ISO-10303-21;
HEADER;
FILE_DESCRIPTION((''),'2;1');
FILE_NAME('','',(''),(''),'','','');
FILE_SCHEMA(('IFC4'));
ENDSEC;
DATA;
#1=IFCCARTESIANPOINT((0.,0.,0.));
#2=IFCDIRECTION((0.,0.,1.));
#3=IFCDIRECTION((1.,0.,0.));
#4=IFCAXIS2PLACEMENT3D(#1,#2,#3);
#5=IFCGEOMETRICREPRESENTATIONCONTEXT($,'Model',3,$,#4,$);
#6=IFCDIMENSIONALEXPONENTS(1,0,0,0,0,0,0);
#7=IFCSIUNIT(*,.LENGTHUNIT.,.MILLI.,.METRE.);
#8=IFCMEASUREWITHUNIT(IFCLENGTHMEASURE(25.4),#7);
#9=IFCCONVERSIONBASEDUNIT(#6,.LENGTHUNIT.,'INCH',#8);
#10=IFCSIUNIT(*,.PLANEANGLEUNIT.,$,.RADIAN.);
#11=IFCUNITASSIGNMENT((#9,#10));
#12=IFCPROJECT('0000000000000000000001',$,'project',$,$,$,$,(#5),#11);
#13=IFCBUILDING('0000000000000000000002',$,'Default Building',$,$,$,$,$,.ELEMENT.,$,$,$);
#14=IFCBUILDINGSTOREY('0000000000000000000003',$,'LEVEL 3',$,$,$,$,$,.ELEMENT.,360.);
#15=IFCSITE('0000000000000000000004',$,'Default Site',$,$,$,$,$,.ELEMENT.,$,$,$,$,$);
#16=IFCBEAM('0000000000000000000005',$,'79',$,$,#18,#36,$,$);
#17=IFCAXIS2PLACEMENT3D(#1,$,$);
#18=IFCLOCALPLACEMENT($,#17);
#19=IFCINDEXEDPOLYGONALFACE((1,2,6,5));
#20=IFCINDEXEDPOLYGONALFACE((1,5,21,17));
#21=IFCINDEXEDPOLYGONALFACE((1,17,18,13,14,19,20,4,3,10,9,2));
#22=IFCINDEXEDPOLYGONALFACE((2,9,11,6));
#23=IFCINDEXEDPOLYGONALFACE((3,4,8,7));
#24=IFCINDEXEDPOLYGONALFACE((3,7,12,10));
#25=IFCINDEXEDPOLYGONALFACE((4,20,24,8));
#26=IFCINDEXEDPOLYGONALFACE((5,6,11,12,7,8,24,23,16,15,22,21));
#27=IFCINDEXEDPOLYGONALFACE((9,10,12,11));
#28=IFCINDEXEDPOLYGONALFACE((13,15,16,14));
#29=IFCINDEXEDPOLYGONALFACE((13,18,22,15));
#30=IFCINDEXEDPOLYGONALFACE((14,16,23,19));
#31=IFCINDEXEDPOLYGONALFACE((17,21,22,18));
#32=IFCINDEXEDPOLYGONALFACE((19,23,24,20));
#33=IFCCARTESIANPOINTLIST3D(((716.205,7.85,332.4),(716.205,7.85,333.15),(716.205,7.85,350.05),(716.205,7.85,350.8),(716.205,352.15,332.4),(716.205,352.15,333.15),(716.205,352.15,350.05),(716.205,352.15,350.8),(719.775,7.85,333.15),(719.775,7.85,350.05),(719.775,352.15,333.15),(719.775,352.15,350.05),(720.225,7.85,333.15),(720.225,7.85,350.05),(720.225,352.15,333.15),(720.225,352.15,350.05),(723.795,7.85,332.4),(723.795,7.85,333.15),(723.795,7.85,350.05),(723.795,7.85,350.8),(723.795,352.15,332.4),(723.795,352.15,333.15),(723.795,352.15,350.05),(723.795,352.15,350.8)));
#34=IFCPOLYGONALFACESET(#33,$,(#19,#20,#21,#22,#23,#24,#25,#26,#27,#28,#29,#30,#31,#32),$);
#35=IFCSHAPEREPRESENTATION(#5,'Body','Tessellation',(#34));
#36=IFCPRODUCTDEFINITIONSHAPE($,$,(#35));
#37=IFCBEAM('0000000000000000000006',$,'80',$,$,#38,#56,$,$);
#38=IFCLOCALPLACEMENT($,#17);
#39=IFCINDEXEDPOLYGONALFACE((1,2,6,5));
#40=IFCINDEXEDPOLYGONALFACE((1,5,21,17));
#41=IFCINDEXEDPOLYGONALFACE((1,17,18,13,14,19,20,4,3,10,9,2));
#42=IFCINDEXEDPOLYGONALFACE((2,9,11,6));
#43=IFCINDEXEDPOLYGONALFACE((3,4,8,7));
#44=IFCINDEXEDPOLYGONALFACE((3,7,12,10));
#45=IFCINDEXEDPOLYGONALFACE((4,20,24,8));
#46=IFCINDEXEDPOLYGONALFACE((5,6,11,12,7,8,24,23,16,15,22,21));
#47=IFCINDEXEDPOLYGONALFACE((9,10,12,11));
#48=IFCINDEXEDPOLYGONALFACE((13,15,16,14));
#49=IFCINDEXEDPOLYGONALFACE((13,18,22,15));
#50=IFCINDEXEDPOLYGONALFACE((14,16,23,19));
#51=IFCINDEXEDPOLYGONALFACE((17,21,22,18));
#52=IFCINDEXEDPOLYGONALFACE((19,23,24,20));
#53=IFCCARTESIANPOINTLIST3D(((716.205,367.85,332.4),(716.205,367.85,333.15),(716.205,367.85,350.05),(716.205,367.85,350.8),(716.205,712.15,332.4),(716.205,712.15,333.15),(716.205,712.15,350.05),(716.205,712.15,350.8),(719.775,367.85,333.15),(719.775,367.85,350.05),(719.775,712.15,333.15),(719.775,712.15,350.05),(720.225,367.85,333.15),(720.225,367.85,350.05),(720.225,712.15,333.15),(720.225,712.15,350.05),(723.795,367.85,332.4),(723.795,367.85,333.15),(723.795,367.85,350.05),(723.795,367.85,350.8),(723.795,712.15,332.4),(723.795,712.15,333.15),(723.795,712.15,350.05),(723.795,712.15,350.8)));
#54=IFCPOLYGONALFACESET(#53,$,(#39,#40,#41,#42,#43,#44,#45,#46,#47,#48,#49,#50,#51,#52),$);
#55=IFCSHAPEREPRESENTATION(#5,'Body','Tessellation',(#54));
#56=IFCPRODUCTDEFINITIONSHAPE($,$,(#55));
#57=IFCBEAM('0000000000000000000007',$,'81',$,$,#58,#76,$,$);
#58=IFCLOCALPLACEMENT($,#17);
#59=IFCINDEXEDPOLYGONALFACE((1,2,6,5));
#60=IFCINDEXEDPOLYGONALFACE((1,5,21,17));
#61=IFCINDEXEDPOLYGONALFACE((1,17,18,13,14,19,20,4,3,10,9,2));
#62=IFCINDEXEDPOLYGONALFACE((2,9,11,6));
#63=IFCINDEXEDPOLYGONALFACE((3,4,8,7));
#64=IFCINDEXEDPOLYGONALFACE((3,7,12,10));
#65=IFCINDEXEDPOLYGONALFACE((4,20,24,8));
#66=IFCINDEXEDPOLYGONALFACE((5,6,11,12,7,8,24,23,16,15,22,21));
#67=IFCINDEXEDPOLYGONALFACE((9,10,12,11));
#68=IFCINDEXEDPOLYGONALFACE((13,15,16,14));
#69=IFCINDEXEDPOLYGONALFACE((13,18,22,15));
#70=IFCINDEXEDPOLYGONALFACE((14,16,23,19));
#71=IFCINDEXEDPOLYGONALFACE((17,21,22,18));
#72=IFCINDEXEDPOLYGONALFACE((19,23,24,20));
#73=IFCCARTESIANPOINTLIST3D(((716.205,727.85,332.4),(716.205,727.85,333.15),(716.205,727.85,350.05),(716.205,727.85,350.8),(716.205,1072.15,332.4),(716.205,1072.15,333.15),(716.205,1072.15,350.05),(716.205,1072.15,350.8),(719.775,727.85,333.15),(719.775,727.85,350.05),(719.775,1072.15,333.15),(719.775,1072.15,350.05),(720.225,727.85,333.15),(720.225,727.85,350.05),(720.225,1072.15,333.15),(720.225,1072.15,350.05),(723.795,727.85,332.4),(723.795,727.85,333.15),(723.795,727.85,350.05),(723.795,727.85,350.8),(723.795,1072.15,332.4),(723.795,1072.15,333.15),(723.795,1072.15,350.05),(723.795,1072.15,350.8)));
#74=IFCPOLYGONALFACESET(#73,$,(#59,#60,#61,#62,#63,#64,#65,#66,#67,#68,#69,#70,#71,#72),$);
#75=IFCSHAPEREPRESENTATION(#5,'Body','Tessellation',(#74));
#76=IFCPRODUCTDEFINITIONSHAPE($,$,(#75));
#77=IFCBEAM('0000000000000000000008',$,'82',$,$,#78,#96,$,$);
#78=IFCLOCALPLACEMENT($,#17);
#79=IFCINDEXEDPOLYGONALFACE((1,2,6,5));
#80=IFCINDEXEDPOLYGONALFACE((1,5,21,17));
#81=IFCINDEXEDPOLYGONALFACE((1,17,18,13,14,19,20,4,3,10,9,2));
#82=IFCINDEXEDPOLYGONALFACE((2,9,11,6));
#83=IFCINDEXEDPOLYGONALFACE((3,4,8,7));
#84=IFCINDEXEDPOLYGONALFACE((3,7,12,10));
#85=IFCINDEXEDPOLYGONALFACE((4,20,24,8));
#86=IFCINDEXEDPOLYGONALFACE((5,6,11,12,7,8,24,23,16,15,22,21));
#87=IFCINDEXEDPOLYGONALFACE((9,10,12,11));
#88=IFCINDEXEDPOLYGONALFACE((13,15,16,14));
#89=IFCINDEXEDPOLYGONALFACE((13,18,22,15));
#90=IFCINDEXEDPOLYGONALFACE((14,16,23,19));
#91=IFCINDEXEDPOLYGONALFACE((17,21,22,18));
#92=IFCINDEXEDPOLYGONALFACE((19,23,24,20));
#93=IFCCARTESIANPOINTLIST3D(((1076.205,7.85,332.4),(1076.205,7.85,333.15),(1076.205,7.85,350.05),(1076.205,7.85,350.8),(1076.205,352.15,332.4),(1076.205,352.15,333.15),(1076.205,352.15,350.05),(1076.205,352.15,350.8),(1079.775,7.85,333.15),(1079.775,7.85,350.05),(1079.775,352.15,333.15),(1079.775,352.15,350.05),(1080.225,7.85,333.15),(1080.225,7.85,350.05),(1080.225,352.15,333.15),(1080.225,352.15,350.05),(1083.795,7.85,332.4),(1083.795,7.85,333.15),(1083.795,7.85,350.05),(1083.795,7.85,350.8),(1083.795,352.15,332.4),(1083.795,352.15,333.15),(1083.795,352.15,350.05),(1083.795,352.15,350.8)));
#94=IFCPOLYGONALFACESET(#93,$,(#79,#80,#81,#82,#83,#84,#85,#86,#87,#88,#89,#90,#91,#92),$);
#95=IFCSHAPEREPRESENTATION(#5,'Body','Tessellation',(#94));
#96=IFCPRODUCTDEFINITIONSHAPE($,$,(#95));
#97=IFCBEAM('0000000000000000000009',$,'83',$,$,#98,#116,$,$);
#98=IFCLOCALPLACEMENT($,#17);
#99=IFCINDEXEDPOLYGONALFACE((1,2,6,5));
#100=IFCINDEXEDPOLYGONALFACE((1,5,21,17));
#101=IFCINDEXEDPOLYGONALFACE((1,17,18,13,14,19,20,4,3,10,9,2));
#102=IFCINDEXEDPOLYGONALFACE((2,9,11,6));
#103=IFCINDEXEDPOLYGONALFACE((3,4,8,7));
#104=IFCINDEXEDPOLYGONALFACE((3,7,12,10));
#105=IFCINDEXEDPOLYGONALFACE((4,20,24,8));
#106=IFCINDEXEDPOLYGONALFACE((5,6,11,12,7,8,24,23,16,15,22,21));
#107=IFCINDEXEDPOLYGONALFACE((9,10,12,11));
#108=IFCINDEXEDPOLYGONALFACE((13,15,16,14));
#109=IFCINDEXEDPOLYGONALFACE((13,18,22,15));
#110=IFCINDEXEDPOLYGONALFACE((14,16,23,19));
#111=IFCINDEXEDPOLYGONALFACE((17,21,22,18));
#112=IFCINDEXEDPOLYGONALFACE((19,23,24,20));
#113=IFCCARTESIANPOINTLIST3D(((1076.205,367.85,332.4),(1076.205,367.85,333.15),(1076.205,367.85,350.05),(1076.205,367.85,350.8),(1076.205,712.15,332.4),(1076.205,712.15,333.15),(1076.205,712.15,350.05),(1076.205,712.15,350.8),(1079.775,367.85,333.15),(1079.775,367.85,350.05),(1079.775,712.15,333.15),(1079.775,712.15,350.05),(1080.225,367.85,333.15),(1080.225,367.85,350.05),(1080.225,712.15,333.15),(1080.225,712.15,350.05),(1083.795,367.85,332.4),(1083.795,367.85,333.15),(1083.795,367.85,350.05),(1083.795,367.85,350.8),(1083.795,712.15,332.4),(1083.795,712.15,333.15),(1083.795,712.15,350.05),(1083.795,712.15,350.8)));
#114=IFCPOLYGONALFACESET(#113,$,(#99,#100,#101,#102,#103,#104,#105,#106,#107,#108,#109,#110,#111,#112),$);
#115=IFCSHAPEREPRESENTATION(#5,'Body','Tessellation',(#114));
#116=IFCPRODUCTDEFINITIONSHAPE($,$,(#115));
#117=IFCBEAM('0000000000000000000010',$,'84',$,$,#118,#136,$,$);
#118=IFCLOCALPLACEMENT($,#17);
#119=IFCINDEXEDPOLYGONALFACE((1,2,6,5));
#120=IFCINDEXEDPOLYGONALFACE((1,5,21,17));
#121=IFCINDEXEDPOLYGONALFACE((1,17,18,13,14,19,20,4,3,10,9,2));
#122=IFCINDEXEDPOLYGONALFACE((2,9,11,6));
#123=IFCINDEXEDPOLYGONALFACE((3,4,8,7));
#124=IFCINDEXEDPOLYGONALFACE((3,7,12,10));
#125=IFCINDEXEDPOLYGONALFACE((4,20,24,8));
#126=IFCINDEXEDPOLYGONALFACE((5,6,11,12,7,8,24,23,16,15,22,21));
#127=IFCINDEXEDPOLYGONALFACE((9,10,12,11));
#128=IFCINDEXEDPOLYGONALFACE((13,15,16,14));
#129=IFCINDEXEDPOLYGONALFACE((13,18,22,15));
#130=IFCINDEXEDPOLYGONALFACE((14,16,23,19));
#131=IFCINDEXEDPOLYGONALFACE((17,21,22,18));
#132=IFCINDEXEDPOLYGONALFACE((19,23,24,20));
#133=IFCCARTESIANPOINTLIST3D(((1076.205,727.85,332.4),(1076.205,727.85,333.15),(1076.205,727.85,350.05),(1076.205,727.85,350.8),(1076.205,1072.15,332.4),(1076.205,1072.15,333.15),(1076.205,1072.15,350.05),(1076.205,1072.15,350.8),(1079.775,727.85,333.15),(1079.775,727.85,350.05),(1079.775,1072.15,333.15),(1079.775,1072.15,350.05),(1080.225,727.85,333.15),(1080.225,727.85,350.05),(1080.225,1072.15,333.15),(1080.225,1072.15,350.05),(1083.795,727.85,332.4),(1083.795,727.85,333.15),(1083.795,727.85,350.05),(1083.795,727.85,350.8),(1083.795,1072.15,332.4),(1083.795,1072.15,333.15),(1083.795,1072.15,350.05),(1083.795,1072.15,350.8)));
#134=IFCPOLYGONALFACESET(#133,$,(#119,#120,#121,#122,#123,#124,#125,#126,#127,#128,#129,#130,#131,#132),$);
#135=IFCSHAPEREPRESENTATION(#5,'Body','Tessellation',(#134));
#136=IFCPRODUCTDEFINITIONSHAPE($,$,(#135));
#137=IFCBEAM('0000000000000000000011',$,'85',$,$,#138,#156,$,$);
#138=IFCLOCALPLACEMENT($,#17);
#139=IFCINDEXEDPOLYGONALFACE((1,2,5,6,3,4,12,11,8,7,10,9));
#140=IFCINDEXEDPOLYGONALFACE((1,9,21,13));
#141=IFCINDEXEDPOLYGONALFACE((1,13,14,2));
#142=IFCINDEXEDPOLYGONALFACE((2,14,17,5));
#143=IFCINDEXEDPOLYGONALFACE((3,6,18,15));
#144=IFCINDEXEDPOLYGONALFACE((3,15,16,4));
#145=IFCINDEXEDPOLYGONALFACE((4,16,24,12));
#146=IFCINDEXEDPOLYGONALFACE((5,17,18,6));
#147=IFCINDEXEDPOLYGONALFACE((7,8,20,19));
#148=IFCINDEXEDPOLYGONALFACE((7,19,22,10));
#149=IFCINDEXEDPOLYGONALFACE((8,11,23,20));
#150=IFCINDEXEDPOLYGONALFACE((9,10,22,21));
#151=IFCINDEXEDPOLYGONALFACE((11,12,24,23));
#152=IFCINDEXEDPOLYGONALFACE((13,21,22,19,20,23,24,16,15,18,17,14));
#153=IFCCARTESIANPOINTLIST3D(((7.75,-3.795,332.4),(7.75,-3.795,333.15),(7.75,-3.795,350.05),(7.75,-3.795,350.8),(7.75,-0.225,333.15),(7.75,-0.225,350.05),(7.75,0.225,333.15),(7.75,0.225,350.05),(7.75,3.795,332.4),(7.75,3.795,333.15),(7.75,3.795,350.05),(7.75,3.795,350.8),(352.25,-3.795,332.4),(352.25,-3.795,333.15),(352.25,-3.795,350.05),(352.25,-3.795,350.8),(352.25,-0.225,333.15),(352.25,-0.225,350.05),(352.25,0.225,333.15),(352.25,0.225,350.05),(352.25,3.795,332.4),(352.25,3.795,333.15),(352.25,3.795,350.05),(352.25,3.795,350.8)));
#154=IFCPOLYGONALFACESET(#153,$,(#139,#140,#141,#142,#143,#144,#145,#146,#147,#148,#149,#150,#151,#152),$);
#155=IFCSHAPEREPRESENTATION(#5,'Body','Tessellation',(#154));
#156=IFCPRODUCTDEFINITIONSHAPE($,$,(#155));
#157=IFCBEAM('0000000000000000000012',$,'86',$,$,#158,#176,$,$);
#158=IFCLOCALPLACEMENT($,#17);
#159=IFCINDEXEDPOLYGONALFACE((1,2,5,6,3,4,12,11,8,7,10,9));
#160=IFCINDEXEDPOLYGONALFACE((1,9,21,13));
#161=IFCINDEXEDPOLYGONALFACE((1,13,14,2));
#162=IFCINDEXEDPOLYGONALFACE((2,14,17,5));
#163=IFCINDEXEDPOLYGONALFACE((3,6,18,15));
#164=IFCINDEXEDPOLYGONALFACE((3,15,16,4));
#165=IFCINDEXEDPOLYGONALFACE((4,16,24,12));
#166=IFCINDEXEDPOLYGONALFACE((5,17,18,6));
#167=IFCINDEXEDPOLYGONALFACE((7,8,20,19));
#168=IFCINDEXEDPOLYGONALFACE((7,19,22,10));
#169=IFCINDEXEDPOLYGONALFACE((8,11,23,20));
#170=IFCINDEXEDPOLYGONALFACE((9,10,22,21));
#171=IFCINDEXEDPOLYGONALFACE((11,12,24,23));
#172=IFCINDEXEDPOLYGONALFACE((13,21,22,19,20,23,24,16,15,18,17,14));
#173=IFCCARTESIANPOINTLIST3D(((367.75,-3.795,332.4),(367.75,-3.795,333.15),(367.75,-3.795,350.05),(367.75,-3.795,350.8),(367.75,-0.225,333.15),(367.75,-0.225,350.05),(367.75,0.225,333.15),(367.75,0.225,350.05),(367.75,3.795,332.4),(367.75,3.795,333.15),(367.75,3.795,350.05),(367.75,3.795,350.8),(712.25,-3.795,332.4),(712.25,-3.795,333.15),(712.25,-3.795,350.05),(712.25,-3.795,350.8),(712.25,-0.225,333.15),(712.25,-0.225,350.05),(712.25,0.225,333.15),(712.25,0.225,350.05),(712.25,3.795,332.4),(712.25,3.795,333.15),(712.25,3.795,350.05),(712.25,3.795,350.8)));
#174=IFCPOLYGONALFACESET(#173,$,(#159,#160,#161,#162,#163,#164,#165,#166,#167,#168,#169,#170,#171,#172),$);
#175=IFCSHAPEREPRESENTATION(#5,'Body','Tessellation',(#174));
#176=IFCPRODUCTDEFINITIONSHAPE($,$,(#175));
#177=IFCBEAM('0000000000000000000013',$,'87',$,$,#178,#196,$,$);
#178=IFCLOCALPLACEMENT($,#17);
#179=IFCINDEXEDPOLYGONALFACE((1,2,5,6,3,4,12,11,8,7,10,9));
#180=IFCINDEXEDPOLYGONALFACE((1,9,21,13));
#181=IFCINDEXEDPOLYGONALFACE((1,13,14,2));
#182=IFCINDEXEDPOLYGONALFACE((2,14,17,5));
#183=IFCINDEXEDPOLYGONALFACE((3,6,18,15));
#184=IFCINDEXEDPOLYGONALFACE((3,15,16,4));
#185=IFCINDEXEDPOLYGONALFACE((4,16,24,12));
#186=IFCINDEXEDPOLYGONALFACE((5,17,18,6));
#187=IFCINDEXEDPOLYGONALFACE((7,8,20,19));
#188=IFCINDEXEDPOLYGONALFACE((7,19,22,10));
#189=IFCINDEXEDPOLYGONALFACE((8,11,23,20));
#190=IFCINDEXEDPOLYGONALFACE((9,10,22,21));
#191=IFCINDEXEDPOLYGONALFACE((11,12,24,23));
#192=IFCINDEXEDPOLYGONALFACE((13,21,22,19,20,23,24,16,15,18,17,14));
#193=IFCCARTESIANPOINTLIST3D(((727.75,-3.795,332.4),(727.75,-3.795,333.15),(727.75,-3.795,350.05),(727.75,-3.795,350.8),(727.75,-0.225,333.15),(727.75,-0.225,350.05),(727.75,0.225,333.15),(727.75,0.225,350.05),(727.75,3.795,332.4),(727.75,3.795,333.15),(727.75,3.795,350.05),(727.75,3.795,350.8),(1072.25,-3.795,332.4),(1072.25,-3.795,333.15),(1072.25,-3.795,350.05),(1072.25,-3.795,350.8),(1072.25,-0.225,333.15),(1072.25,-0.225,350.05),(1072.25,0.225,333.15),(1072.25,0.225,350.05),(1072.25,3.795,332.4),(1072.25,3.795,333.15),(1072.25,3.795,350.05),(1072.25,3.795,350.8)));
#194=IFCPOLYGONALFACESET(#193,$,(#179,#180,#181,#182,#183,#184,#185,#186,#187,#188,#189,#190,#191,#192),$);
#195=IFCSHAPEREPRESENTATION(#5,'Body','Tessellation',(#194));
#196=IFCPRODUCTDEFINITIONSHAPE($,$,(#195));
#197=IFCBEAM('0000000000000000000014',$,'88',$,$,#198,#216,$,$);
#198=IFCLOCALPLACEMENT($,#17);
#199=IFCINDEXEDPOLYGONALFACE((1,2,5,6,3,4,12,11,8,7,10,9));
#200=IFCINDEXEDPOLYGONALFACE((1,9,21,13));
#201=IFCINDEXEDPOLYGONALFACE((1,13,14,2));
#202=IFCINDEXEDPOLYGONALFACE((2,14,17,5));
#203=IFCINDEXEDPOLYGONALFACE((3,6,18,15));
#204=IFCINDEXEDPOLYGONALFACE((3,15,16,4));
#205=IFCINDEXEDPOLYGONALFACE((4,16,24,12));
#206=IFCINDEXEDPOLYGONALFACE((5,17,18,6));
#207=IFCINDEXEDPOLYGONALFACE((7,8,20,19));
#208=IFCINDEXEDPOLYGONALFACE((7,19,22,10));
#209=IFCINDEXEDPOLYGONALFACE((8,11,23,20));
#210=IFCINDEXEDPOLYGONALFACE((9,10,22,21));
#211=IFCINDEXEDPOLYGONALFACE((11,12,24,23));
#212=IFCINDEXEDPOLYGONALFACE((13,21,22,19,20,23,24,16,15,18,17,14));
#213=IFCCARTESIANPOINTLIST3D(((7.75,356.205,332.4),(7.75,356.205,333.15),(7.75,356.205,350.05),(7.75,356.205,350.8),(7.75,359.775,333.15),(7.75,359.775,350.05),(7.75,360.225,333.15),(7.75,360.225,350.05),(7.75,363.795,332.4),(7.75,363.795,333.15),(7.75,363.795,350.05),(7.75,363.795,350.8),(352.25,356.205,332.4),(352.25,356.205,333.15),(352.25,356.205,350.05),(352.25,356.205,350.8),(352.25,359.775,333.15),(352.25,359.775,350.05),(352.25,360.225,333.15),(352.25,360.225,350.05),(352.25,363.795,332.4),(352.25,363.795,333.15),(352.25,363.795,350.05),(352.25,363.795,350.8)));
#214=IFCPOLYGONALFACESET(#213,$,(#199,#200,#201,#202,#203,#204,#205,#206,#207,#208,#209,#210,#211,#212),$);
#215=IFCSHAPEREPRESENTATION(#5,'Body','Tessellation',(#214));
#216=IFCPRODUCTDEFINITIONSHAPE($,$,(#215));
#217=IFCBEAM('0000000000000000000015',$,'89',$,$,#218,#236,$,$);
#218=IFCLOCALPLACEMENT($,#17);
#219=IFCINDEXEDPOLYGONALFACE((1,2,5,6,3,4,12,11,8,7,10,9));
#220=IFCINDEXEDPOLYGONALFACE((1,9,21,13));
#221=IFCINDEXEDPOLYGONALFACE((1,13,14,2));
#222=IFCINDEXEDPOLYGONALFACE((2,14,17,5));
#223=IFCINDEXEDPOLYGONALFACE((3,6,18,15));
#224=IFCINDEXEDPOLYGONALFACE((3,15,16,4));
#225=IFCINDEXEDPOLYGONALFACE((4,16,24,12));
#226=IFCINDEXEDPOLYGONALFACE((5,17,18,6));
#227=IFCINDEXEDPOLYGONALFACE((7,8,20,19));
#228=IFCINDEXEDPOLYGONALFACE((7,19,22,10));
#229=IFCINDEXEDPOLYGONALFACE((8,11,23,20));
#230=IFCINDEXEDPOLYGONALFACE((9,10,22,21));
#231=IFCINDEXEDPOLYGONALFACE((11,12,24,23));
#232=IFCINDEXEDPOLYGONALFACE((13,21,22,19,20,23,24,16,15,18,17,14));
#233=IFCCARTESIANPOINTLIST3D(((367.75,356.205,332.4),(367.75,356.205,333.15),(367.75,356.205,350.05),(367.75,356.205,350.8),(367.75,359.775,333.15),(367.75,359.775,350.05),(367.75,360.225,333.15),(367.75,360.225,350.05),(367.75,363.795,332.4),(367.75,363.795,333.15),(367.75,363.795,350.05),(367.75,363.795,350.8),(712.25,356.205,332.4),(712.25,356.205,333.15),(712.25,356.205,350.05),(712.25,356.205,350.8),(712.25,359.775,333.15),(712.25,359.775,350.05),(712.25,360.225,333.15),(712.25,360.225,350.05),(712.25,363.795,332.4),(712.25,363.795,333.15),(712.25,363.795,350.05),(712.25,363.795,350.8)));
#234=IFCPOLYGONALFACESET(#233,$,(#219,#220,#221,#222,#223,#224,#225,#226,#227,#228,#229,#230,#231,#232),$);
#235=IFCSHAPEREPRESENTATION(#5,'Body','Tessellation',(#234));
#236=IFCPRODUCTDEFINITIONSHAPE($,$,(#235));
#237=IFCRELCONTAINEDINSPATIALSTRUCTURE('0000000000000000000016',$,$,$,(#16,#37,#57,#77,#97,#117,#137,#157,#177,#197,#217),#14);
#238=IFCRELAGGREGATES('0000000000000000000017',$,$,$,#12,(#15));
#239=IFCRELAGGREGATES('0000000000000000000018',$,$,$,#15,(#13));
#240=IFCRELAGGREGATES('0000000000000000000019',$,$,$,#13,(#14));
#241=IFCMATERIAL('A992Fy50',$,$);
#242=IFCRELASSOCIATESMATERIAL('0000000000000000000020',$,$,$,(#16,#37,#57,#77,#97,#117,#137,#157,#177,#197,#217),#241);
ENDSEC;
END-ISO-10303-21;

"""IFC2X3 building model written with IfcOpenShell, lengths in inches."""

from ifc_helpers import new_model, entity, si_unit, converted_unit, frame, origin_with_axes, origin_2d_with_axis, place, context, project, spatial, i_section, transform_2d, derived_profile, extrude, material, element, save


model = new_model("IFC2X3")

# Units and contexts
model_context = context("Model", 3, world=origin_with_axes())
ifc_project = project(units=[converted_unit("LENGTHUNIT", "INCH", entity("IfcLengthMeasure", 25.4), si_unit("LENGTHUNIT", "METRE", prefix="MILLI"), dimensions=[1, 0, 0, 0, 0, 0, 0]), si_unit("PLANEANGLEUNIT", "RADIAN")], contexts=[model_context])

# Site, building, storey
site = spatial("IfcSite", under=ifc_project, Name="Default Site", CompositionType="ELEMENT")
building = spatial("IfcBuilding", under=site, Name="Default Building", CompositionType="ELEMENT")
storey = spatial("IfcBuildingStorey", under=building, Name="LEVEL 3", CompositionType="ELEMENT", Elevation=360.0)

# Shared definitions
ifc_material = material(Name="A992Fy50")

# Beams
for number, where, z_axis, x_axis, name in (
    (1, (720.0, 7.85, 360.0), (0.0, 1.0, 0.0), (-1.0, 0.0, 0.0), "79"),
    (2, (720.0, 367.85, 360.0), (0.0, 1.0, 0.0), (-1.0, 0.0, 0.0), "80"),
    (3, (720.0, 727.85, 360.0), (0.0, 1.0, 0.0), (-1.0, 0.0, 0.0), "81"),
    (4, (1080.0, 7.85, 360.0), (0.0, 1.0, 0.0), (-1.0, 0.0, 0.0), "82"),
    (5, (1080.0, 367.85, 360.0), (0.0, 1.0, 0.0), (-1.0, 0.0, 0.0), "83"),
    (6, (1080.0, 727.85, 360.0), (0.0, 1.0, 0.0), (-1.0, 0.0, 0.0), "84"),
):
    element("IfcBeam", number, at=place(None, frame(where, z_axis=z_axis, x_axis=x_axis)), inside=storey, material=ifc_material, Name=name, context=model_context, shape_type="SweptSolid", body=[
        extrude(derived_profile(i_section(OverallWidth=7.59, OverallDepth=18.4, WebThickness=0.45, FlangeThickness=0.75, at=origin_2d_with_axis()), transform_2d((0.0, -9.2))), origin_with_axes(), (0.0, 0.0, 1.0), 344.3),
    ])
for number, where, z_axis, x_axis, name in (
    (7, (7.75, 0.0, 360.0), (1.0, 0.0, 0.0), (0.0, 1.0, 0.0), "85"),
    (8, (367.75, 0.0, 360.0), (1.0, 0.0, 0.0), (0.0, 1.0, 0.0), "86"),
    (9, (727.75, 0.0, 360.0), (1.0, 0.0, 0.0), (0.0, 1.0, 0.0), "87"),
    (10, (7.75, 360.0, 360.0), (1.0, 0.0, 0.0), (0.0, 1.0, 0.0), "88"),
    (11, (367.75, 360.0, 360.0), (1.0, 0.0, 0.0), (0.0, 1.0, 0.0), "89"),
):
    element("IfcBeam", number, at=place(None, frame(where, z_axis=z_axis, x_axis=x_axis)), inside=storey, material=ifc_material, Name=name, context=model_context, shape_type="SweptSolid", body=[
        extrude(derived_profile(i_section(OverallWidth=7.59, OverallDepth=18.4, WebThickness=0.45, FlangeThickness=0.75, at=origin_2d_with_axis()), transform_2d((0.0, -9.2))), origin_with_axes(), (0.0, 0.0, 1.0), 344.5),
    ])

save(model, "model.ifc")
